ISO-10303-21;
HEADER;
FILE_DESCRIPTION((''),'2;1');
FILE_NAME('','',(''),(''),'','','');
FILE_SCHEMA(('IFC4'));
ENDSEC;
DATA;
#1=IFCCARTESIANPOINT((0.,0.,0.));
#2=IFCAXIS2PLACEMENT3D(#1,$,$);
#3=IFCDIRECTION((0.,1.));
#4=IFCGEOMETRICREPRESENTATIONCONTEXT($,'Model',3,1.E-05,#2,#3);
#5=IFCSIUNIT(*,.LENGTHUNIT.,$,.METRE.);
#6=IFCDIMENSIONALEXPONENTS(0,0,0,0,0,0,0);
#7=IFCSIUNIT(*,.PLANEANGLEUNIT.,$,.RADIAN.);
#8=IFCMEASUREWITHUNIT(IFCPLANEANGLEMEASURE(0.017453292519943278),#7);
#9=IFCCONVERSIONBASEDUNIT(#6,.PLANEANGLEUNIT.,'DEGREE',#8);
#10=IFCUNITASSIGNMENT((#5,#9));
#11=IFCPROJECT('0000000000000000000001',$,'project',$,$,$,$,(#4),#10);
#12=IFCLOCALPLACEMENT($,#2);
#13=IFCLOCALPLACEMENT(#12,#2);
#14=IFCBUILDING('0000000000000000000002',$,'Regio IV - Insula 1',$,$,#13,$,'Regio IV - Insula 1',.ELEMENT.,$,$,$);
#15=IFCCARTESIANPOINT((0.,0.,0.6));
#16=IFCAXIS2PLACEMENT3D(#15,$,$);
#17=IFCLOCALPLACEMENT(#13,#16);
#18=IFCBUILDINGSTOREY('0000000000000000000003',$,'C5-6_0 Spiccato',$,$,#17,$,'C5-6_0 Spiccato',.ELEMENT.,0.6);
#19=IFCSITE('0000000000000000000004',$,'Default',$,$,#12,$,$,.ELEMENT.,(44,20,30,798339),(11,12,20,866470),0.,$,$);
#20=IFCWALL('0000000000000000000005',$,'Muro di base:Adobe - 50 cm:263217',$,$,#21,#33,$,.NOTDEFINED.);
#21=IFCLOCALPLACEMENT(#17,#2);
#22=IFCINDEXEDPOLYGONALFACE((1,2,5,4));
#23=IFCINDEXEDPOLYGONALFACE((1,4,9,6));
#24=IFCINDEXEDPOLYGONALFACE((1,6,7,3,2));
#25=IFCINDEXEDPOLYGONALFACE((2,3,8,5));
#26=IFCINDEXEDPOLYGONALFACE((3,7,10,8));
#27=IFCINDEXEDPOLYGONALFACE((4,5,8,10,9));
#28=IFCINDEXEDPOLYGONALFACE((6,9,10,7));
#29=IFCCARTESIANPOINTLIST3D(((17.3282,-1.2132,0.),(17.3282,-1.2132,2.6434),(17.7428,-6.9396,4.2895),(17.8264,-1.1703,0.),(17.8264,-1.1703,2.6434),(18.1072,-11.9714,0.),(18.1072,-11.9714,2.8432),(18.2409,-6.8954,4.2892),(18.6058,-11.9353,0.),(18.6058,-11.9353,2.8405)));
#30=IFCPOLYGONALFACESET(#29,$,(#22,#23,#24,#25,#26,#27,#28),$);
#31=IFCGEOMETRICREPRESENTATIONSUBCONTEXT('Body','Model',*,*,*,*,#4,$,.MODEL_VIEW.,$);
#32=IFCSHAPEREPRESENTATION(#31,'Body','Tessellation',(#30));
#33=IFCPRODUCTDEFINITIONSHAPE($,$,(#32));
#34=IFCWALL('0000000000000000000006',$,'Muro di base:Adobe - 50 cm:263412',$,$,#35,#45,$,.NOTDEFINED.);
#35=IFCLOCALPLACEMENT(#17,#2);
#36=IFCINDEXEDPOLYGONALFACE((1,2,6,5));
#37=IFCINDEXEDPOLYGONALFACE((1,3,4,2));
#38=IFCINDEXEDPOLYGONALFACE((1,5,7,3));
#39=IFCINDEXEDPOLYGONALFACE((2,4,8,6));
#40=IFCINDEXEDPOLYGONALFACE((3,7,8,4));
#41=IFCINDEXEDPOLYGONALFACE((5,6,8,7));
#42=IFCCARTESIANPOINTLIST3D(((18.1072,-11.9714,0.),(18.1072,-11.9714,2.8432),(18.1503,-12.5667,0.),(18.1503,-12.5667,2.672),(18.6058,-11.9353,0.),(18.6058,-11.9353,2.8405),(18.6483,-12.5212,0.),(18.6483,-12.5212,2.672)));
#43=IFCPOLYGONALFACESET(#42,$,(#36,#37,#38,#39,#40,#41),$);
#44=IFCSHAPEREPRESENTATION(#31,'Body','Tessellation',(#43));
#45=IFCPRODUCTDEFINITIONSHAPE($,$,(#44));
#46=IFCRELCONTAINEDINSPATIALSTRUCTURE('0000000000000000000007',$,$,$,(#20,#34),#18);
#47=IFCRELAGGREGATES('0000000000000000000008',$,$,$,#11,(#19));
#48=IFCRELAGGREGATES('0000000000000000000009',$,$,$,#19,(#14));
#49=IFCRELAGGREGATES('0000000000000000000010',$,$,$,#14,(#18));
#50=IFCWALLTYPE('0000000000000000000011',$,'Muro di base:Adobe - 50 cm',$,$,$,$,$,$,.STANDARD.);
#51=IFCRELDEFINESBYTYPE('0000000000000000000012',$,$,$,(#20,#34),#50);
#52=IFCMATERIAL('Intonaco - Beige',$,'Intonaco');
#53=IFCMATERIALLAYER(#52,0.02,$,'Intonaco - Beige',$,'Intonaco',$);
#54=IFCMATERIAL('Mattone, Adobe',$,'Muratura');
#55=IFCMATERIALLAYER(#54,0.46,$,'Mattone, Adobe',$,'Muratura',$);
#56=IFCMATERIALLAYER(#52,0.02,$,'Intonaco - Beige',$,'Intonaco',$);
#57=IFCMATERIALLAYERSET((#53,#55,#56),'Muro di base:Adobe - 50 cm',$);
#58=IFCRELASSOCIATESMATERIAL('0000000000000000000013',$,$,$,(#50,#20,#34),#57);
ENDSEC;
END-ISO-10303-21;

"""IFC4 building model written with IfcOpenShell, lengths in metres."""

from ifc_helpers import new_model, entity, si_unit, converted_unit, direction, frame, origin, place, context, subcontext, project, spatial, polyline, outline, extrude, clip, bounded_halfspace, material, layer, layer_set, layer_usage, type_object, element, save


model = new_model("IFC4")

# Units and contexts
model_context = context("Model", 3, precision=1e-05, world=origin(), true_north=direction((0.0, 1.0)))
body_context = subcontext(model_context, "Body", "Model", "MODEL_VIEW")
ifc_project = project(units=[si_unit("LENGTHUNIT", "METRE"), converted_unit("PLANEANGLEUNIT", "DEGREE", entity("IfcPlaneAngleMeasure", 0.017453292519943278), si_unit("PLANEANGLEUNIT", "RADIAN"), dimensions=[0, 0, 0, 0, 0, 0, 0])], contexts=[model_context])

# Site, building, storey
site_placement = place(None, origin())
site = spatial("IfcSite", under=ifc_project, at=site_placement, Name="Default", CompositionType="ELEMENT", RefLatitude=(44, 20, 30, 798339), RefLongitude=(11, 12, 20, 866470), RefElevation=0.0)
building_placement = place(site_placement, origin())
building = spatial("IfcBuilding", under=site, at=building_placement, Name="Regio IV - Insula 1", LongName="Regio IV - Insula 1", CompositionType="ELEMENT")
storey_placement = place(building_placement, frame((0.0, 0.0, 0.6)))
storey = spatial("IfcBuildingStorey", under=building, at=storey_placement, Name="C5-6_0 Spiccato", LongName="C5-6_0 Spiccato", CompositionType="ELEMENT", Elevation=0.6)

# Shared definitions
ifc_material_1 = material(Name="Intonaco - Beige", Category="Intonaco")
ifc_material_2 = material(Name="Mattone, Adobe", Category="Muratura")
ifc_layer_1 = layer(ifc_material_1, 0.02, Name="Intonaco - Beige", Category="Intonaco")
ifc_layer_2 = layer(ifc_material_2, 0.46, Name="Mattone, Adobe", Category="Muratura")
ifc_layer_3 = layer(ifc_material_1, 0.02, Name="Intonaco - Beige", Category="Intonaco")
ifc_layer_set_1 = layer_set([ifc_layer_1, ifc_layer_2, ifc_layer_3], Name="Muro di base:Adobe - 50 cm")
wall_type_1 = type_object("IfcWallType", Name="Muro di base:Adobe - 50 cm", PredefinedType="STANDARD", material=ifc_layer_set_1)

# Walls
ifc_layer_usage_1 = layer_usage(ifc_layer_set_1, "AXIS2", "NEGATIVE", 0.25)
wall_1_placement = place(storey_placement, frame((18.3565, -11.9534, 0.0), z_axis=(0.0, 0.0, 1.0), x_axis=(-0.07222, 0.997389, 0.0)))
element("IfcWall", 1, at=wall_1_placement, inside=storey, type_object=wall_type_1, material=ifc_layer_usage_1, Name="Muro di base:Adobe - 50 cm:263217", PredefinedType="NOTDEFINED", context=body_context, shape_type="Clipping", body=[
    clip(clip(extrude(outline(polyline([(10.7932, -0.25), (10.7864, 0.25), (0.0, 0.25), (0.0, -0.25), (10.7932, -0.25)])), origin(), (0.0, 0.0, 1.0), 4.2895), bounded_halfspace(frame((5.0531, -0.25, 4.2892), z_axis=(0.275612, 0.003755, 0.961262), x_axis=(-0.013623, 0.999907, 0.0)), False, frame((5.0531, -0.25, 4.2892)), polyline([(0.0, 0.0), (5.7401, 0.0), (5.7333, 0.5), (-0.0081, 0.5), (0.0, 0.0)]))), bounded_halfspace(frame((0.0, -0.25, 2.8405), z_axis=(-0.275589, -0.005177, 0.961262), x_axis=(0.018783, -0.999824, 0.0)), False, frame((0.0, -0.25, 2.8405)), polyline([(0.0, 0.0), (5.0531, 0.0), (5.045, 0.5), (0.0, 0.5), (0.0, 0.0)]))),
])
ifc_layer_usage_2 = layer_usage(ifc_layer_set_1, "AXIS2", "NEGATIVE", 0.25)
wall_2_placement = place(storey_placement, frame((18.3565, -11.9534, 0.0), z_axis=(0.0, 0.0, 1.0), x_axis=(0.07222, -0.997389, 0.0)))
element("IfcWall", 2, at=wall_2_placement, inside=storey, type_object=wall_type_1, material=ifc_layer_usage_2, Name="Muro di base:Adobe - 50 cm:263412", PredefinedType="NOTDEFINED", context=body_context, shape_type="Clipping", body=[
    clip(extrude(outline(polyline([(0.5968, -0.25), (0.5874, 0.25), (0.0, 0.25), (0.0, -0.25), (0.5968, -0.25)])), origin(), (0.0, 0.0, 1.0), 2.8432), bounded_halfspace(frame((0.0, -0.25, 2.8432), z_axis=(0.275589, 0.005177, 0.961262), x_axis=(-0.018783, 0.999824, 0.0)), False, frame((0.0, -0.25, 2.8432)), polyline([(0.0, 0.0), (0.5968, 0.0), (0.5874, 0.5), (0.0, 0.5), (0.0, 0.0)]))),
])

save(model, "model.ifc")
